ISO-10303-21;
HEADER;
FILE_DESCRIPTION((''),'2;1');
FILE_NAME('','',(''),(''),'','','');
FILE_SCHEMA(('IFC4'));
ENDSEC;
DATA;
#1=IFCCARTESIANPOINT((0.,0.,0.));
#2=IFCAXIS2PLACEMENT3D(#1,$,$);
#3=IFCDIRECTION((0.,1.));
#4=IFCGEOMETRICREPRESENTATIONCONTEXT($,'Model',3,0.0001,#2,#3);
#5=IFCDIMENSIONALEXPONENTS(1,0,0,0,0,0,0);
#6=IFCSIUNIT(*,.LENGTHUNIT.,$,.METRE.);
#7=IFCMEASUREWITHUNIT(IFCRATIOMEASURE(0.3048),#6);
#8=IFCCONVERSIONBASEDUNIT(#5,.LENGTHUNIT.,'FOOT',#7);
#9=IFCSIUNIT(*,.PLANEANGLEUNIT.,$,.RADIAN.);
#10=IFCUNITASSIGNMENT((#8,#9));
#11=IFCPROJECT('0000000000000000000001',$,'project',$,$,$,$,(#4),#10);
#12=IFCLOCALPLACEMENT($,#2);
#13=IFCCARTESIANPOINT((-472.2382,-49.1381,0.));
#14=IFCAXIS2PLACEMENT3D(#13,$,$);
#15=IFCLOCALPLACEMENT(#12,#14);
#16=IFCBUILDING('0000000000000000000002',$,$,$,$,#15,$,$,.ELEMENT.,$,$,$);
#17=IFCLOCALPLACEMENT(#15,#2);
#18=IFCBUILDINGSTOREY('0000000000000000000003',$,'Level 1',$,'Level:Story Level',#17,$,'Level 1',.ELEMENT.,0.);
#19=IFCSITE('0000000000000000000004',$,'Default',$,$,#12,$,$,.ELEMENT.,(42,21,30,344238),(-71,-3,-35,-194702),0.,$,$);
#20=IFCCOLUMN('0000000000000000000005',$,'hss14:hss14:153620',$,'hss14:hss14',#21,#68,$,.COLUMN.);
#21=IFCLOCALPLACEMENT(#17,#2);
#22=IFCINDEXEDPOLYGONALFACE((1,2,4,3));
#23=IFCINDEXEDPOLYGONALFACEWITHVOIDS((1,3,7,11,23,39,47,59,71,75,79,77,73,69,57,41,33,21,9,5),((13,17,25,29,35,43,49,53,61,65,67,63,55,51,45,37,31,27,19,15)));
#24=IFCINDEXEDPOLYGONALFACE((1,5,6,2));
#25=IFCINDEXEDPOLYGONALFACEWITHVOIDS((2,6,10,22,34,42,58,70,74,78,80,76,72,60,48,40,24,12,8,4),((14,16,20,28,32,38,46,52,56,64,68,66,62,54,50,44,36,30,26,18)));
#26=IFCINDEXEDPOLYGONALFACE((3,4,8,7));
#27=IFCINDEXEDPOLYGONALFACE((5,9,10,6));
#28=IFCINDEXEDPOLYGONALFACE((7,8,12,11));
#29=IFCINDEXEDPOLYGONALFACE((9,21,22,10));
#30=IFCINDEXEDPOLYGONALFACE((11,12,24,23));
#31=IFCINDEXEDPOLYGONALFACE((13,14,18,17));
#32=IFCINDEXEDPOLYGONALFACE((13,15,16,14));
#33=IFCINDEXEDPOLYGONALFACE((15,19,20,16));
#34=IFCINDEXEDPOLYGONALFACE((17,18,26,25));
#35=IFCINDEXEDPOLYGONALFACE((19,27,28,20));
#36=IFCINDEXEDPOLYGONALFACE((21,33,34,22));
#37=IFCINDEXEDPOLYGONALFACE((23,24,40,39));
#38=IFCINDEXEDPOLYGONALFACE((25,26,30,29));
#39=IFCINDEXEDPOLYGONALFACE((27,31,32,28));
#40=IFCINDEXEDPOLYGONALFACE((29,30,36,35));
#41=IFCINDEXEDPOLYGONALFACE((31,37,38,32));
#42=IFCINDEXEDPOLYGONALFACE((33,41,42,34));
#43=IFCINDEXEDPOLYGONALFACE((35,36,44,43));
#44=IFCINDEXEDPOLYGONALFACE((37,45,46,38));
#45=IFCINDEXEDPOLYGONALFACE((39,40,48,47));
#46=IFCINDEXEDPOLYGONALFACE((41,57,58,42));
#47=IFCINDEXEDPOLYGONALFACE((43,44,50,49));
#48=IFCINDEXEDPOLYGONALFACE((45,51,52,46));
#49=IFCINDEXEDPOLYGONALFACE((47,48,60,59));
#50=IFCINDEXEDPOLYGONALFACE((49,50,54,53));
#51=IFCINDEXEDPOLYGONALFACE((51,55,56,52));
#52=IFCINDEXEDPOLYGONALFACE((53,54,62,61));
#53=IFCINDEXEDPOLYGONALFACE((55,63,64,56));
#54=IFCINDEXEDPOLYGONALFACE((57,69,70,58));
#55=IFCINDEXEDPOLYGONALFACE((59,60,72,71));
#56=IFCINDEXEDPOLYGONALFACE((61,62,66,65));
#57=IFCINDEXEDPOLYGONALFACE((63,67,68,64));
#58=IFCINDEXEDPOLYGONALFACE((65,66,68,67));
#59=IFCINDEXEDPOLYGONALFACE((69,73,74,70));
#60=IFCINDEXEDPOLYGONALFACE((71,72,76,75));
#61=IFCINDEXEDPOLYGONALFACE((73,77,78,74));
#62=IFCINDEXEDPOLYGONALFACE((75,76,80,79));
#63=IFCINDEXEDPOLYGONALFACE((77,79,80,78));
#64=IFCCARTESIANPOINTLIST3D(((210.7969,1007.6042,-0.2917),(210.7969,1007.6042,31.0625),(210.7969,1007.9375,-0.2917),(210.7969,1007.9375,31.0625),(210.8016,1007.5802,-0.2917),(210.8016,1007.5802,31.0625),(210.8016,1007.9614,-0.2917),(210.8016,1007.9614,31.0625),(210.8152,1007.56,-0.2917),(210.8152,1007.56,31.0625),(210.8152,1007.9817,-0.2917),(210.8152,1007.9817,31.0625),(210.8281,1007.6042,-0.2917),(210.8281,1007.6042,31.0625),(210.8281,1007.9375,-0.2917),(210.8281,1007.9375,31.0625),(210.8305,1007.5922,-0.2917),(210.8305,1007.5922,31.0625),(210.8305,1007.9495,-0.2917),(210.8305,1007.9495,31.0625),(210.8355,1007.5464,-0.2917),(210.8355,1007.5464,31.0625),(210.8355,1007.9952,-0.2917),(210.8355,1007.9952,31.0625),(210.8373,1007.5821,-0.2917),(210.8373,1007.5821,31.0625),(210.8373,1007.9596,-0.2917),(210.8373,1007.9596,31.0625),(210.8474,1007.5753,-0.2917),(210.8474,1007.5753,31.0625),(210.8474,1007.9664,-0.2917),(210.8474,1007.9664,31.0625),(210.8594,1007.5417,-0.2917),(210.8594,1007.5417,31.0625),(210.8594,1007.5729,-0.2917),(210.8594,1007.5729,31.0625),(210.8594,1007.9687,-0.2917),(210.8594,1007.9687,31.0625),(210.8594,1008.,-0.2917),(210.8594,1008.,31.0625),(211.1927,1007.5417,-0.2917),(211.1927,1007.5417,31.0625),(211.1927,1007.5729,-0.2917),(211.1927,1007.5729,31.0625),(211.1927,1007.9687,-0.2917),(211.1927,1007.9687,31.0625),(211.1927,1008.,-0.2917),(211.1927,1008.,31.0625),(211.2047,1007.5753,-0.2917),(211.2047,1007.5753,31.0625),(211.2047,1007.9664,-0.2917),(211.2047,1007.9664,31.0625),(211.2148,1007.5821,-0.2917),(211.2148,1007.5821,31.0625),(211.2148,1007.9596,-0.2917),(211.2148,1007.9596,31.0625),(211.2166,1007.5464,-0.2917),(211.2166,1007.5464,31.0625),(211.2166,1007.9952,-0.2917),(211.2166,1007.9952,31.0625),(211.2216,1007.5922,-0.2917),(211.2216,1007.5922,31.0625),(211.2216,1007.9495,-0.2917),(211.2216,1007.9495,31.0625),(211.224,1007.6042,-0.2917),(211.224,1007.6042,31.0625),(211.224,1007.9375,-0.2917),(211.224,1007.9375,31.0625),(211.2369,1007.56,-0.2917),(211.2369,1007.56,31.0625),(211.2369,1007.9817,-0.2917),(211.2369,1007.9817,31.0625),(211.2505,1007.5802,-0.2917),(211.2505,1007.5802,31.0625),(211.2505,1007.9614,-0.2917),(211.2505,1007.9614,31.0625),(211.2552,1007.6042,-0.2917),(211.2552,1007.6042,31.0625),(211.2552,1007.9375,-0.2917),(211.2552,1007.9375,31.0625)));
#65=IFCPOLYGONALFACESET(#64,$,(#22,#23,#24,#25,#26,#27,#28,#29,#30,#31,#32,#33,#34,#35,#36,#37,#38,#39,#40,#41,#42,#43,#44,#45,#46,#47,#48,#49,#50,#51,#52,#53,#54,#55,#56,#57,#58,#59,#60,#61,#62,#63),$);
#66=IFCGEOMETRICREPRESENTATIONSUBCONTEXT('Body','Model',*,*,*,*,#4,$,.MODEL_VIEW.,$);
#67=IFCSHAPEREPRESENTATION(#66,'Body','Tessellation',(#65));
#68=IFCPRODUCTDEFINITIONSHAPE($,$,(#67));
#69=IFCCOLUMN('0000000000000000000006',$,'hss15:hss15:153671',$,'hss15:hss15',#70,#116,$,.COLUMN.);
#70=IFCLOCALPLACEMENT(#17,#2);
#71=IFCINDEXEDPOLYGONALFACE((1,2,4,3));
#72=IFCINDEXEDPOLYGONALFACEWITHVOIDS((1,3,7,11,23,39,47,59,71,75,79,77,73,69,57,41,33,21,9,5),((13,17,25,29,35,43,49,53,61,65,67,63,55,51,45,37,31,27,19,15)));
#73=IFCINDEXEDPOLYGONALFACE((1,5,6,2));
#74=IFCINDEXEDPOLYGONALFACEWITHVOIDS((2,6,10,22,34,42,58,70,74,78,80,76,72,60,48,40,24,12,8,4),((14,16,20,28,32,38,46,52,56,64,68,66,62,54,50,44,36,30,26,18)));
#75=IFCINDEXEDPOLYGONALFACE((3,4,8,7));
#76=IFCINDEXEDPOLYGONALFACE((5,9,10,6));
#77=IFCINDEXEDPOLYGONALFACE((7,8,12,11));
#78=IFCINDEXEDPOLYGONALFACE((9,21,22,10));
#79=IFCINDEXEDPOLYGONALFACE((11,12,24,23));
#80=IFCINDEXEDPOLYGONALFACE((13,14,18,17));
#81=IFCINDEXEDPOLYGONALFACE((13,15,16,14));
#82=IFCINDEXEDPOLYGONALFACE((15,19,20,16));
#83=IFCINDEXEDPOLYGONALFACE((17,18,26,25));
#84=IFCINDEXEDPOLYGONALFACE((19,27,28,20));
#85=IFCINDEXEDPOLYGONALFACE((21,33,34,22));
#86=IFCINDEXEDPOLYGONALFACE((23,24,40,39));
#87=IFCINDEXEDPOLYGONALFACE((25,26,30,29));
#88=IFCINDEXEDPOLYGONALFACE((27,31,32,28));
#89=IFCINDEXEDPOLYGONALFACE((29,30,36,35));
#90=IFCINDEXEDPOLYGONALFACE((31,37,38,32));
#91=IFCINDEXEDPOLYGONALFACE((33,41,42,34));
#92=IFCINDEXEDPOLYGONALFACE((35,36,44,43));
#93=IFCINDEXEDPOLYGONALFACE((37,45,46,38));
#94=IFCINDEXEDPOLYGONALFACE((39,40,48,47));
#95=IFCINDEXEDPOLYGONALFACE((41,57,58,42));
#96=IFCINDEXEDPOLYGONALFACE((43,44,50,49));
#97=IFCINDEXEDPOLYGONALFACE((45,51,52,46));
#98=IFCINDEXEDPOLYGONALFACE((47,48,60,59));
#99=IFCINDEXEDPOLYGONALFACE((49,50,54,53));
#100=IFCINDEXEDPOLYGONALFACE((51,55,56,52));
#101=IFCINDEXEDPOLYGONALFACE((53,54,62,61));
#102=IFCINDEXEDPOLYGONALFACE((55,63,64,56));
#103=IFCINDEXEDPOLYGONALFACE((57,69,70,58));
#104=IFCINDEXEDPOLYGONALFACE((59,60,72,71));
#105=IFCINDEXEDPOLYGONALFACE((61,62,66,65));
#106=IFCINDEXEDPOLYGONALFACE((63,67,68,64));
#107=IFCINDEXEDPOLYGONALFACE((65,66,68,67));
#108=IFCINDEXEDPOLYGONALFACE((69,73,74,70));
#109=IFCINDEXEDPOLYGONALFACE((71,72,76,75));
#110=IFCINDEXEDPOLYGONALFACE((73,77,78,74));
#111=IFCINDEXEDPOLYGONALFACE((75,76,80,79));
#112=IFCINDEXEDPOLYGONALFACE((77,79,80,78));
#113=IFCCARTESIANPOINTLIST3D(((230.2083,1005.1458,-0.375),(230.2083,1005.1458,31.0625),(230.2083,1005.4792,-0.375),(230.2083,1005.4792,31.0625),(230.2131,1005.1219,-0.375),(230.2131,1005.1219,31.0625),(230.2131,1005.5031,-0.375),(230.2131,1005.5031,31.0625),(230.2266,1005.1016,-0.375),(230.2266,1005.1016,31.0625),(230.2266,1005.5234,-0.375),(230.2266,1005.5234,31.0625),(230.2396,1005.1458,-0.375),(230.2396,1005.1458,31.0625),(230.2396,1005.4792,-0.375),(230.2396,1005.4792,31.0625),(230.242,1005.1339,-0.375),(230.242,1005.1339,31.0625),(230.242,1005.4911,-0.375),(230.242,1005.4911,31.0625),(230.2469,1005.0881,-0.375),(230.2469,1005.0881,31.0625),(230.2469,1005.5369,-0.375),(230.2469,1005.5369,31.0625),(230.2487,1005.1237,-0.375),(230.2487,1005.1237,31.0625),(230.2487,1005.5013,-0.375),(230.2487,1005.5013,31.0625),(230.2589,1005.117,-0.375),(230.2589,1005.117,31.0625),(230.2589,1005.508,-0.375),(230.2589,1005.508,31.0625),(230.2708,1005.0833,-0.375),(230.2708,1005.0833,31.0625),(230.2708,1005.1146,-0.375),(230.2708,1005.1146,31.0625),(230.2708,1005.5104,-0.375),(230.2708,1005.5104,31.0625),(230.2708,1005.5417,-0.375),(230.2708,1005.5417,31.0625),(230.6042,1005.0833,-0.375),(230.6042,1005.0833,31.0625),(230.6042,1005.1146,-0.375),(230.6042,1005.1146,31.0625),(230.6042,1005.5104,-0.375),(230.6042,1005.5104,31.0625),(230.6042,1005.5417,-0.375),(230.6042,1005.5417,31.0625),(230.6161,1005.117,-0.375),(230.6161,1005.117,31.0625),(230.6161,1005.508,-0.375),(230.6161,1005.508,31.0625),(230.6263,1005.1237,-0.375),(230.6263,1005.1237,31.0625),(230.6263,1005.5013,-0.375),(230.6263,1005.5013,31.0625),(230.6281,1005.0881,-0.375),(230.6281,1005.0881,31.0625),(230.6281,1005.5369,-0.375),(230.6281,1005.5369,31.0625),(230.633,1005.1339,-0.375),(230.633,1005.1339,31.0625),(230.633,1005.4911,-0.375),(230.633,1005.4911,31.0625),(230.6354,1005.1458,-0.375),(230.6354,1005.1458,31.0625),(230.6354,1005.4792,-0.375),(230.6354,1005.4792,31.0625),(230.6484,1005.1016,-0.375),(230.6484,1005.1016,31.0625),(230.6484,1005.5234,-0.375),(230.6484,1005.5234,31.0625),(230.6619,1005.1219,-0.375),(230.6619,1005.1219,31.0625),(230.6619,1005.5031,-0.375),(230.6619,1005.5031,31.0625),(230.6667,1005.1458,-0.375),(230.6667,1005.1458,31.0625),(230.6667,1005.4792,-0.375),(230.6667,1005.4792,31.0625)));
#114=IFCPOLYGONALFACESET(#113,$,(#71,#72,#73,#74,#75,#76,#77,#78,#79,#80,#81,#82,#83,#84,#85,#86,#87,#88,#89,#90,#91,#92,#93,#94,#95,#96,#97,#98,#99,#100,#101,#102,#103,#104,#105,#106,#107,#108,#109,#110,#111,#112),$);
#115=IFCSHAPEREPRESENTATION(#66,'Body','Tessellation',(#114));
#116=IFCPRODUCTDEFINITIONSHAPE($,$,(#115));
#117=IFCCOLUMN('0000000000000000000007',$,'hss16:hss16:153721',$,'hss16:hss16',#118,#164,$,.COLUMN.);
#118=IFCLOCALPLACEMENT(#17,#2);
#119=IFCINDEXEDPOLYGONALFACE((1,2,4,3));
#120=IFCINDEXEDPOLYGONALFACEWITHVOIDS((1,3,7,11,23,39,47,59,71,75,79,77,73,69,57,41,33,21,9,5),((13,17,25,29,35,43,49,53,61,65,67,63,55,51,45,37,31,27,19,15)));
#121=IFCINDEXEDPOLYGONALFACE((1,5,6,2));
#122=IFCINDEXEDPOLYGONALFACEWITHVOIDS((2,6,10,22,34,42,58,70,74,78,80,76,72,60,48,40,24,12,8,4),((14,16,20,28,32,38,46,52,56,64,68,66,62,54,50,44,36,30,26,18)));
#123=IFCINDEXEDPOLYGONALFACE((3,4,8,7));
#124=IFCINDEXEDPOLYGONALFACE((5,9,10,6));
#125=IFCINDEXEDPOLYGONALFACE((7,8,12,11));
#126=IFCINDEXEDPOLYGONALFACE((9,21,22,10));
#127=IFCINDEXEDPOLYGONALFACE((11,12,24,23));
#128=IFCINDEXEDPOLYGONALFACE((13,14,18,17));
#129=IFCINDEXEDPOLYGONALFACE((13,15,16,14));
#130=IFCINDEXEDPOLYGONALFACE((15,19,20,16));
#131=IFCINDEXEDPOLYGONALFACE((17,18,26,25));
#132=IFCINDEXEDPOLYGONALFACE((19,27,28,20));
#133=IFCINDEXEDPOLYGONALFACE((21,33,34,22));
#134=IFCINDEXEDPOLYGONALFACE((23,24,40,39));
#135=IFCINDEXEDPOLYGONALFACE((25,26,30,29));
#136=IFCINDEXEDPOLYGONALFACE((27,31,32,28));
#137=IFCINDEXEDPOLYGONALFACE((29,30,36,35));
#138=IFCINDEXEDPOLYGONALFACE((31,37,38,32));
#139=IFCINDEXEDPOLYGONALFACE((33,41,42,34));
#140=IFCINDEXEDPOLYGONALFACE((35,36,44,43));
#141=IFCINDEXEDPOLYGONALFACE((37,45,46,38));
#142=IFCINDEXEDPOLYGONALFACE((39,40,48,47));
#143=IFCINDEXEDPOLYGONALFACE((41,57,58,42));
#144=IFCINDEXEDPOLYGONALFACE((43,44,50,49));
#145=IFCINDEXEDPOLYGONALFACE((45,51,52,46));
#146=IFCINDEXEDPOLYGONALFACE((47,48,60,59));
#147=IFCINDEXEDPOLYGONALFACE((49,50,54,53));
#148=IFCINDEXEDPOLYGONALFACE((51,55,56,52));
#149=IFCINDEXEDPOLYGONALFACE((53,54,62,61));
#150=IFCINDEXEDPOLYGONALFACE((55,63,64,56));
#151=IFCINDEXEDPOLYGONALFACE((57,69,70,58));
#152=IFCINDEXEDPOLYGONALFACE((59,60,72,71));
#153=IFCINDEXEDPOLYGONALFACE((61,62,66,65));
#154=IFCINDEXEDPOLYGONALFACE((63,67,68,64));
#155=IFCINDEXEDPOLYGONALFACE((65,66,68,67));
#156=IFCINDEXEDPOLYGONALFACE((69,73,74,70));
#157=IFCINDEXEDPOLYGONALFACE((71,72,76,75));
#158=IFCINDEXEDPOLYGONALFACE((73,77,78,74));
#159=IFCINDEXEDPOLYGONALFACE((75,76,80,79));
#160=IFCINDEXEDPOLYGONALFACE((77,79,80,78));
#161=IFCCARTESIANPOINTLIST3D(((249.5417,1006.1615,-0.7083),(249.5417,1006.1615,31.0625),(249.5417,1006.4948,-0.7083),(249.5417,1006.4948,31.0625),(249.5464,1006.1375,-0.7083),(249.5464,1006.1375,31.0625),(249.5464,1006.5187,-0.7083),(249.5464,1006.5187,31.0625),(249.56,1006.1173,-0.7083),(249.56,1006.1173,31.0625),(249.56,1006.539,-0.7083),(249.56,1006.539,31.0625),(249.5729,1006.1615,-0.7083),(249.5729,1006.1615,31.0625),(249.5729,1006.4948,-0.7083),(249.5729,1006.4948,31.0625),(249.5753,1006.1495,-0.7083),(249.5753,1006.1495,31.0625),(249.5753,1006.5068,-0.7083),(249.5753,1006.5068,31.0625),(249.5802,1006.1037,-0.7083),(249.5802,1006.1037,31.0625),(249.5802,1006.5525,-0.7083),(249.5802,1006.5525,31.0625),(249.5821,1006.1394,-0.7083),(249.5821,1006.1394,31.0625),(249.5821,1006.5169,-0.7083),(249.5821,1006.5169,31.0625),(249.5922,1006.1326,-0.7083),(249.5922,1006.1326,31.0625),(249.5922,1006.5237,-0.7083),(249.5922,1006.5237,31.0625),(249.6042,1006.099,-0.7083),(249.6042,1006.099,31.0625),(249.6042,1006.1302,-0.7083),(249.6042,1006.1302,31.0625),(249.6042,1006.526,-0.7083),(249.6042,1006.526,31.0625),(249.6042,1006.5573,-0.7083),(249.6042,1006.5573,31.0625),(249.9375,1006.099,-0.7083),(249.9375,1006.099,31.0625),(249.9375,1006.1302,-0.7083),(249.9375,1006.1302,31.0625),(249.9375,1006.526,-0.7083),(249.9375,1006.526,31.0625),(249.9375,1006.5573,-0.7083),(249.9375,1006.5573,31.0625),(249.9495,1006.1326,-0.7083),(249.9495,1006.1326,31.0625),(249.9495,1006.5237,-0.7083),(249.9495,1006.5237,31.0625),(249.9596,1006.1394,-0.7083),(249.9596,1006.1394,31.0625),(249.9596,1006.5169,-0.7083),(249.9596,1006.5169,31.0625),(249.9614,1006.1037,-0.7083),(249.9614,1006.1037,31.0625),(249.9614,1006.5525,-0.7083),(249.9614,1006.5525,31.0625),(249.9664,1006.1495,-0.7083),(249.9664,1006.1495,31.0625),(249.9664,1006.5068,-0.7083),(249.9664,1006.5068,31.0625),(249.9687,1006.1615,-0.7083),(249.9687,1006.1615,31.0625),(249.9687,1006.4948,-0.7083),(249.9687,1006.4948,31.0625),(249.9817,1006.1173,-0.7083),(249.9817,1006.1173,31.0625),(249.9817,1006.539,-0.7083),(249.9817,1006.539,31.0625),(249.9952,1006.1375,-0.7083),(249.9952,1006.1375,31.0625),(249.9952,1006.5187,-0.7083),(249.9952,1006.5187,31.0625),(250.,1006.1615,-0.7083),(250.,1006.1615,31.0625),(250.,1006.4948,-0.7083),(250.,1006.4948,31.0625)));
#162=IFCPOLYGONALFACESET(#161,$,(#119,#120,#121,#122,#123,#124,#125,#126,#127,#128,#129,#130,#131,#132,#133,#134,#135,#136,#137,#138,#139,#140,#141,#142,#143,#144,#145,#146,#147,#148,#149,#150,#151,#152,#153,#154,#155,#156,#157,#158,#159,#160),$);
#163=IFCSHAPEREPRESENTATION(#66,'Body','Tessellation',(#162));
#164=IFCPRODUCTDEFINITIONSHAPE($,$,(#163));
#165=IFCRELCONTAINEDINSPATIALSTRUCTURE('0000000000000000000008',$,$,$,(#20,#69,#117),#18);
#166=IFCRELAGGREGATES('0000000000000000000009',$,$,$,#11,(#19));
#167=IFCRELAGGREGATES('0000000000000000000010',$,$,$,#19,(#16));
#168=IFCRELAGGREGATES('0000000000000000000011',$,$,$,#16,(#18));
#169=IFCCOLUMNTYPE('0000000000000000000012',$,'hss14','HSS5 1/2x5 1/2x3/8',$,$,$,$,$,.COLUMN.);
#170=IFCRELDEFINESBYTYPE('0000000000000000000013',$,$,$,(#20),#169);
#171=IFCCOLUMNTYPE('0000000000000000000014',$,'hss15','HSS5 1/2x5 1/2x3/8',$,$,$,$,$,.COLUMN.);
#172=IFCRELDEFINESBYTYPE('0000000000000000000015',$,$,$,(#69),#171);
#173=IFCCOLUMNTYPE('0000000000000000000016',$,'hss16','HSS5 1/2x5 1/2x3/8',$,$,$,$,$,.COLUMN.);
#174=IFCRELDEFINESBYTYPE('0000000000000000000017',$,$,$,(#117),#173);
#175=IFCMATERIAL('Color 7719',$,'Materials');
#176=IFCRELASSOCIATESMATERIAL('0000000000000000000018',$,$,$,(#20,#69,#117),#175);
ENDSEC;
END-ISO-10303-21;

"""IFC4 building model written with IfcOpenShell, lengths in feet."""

from ifc_helpers import new_model, entity, si_unit, converted_unit, direction, frame, origin, place, context, subcontext, project, spatial, polyline, outline, extrude, boolean, source, transform, mapped, material, type_object, type_shapes, element, save


model = new_model("IFC4")

# Units and contexts
model_context = context("Model", 3, precision=0.0001, world=origin(), true_north=direction((0.0, 1.0)))
body_context = subcontext(model_context, "Body", "Model", "MODEL_VIEW")
ifc_project = project(units=[converted_unit("LENGTHUNIT", "FOOT", entity("IfcRatioMeasure", 0.3048), si_unit("LENGTHUNIT", "METRE"), dimensions=[1, 0, 0, 0, 0, 0, 0]), si_unit("PLANEANGLEUNIT", "RADIAN")], contexts=[model_context])

# Site, building, storey
site_placement = place(None, origin())
site = spatial("IfcSite", under=ifc_project, at=site_placement, Name="Default", CompositionType="ELEMENT", RefLatitude=(42, 21, 30, 344238), RefLongitude=(-71, -3, -35, -194702), RefElevation=0.0)
building_placement = place(site_placement, frame((-472.2382, -49.1381, 0.0)))
building = spatial("IfcBuilding", under=site, at=building_placement, CompositionType="ELEMENT")
storey_placement = place(building_placement, origin())
storey = spatial("IfcBuildingStorey", under=building, at=storey_placement, Name="Level 1", ObjectType="Level:Story Level", LongName="Level 1", CompositionType="ELEMENT", Elevation=0.0)

# Columns
ifc_material_1 = material(Name="Color 7719", Category="Materials")
column_type_1 = type_object("IfcColumnType", Name="hss14", Description="HSS5 1/2x5 1/2x3/8", PredefinedType="COLUMN")
shared_shape_1 = source(origin(), body_context, "Body", "CSG", [
    boolean("DIFFERENCE", extrude(outline(polyline([(-0.1667, -0.2292), (0.1667, -0.2292), (0.1906, -0.2244), (0.2109, -0.2109), (0.2244, -0.1906), (0.2292, -0.1667), (0.2292, 0.1667), (0.2244, 0.1906), (0.2109, 0.2109), (0.1906, 0.2244), (0.1667, 0.2292), (-0.1667, 0.2292), (-0.1906, 0.2244), (-0.2109, 0.2109), (-0.2244, 0.1906), (-0.2292, 0.1667), (-0.2292, -0.1667), (-0.2244, -0.1906), (-0.2109, -0.2109), (-0.1906, -0.2244), (-0.1667, -0.2292)])), frame((211.026, 1007.7708, -0.2917), z_axis=(0.0, 0.0, 1.0), x_axis=(0.0, -1.0, 0.0)), (0.0, 0.0, 1.0), 31.3542), extrude(outline(polyline([(-0.1667, -0.1979), (0.1667, -0.1979), (0.1786, -0.1955), (0.1888, -0.1888), (0.1955, -0.1786), (0.1979, -0.1667), (0.1979, 0.1667), (0.1955, 0.1786), (0.1888, 0.1888), (0.1786, 0.1955), (0.1667, 0.1979), (-0.1667, 0.1979), (-0.1786, 0.1955), (-0.1888, 0.1888), (-0.1955, 0.1786), (-0.1979, 0.1667), (-0.1979, -0.1667), (-0.1955, -0.1786), (-0.1888, -0.1888), (-0.1786, -0.1955), (-0.1667, -0.1979)])), frame((211.026, 1007.7708, 31.0625), z_axis=(0.0, 0.0, -1.0), x_axis=(0.0, -1.0, 0.0)), (0.0, 0.0, 1.0), 31.3542)),
])
type_shapes(column_type_1, [shared_shape_1])
column_1_placement = place(building_placement, origin())
element("IfcColumn", 1, at=column_1_placement, inside=storey, type_object=column_type_1, material=ifc_material_1, Name="hss14:hss14:153620", ObjectType="hss14:hss14", PredefinedType="COLUMN", context=body_context, shape_type="MappedRepresentation", body=[
    mapped(shared_shape_1, transform((0.0, 0.0, 0.0), scale=1.0)),
])
column_type_2 = type_object("IfcColumnType", Name="hss15", Description="HSS5 1/2x5 1/2x3/8", PredefinedType="COLUMN")
shared_shape_2 = source(origin(), body_context, "Body", "CSG", [
    boolean("DIFFERENCE", extrude(outline(polyline([(-0.1667, -0.2292), (0.1667, -0.2292), (0.1906, -0.2244), (0.2109, -0.2109), (0.2244, -0.1906), (0.2292, -0.1667), (0.2292, 0.1667), (0.2244, 0.1906), (0.2109, 0.2109), (0.1906, 0.2244), (0.1667, 0.2292), (-0.1667, 0.2292), (-0.1906, 0.2244), (-0.2109, 0.2109), (-0.2244, 0.1906), (-0.2292, 0.1667), (-0.2292, -0.1667), (-0.2244, -0.1906), (-0.2109, -0.2109), (-0.1906, -0.2244), (-0.1667, -0.2292)])), frame((230.4375, 1005.3125, -0.375), z_axis=(0.0, 0.0, 1.0), x_axis=(0.0, -1.0, 0.0)), (0.0, 0.0, 1.0), 31.4375), extrude(outline(polyline([(-0.1667, -0.1979), (0.1667, -0.1979), (0.1786, -0.1955), (0.1888, -0.1888), (0.1955, -0.1786), (0.1979, -0.1667), (0.1979, 0.1667), (0.1955, 0.1786), (0.1888, 0.1888), (0.1786, 0.1955), (0.1667, 0.1979), (-0.1667, 0.1979), (-0.1786, 0.1955), (-0.1888, 0.1888), (-0.1955, 0.1786), (-0.1979, 0.1667), (-0.1979, -0.1667), (-0.1955, -0.1786), (-0.1888, -0.1888), (-0.1786, -0.1955), (-0.1667, -0.1979)])), frame((230.4375, 1005.3125, 31.0625), z_axis=(0.0, 0.0, -1.0), x_axis=(0.0, -1.0, 0.0)), (0.0, 0.0, 1.0), 31.4375)),
])
type_shapes(column_type_2, [shared_shape_2])
column_2_placement = place(building_placement, origin())
element("IfcColumn", 2, at=column_2_placement, inside=storey, type_object=column_type_2, material=ifc_material_1, Name="hss15:hss15:153671", ObjectType="hss15:hss15", PredefinedType="COLUMN", context=body_context, shape_type="MappedRepresentation", body=[
    mapped(shared_shape_2, transform((0.0, 0.0, 0.0), scale=1.0)),
])
column_type_3 = type_object("IfcColumnType", Name="hss16", Description="HSS5 1/2x5 1/2x3/8", PredefinedType="COLUMN")
shared_shape_3 = source(origin(), body_context, "Body", "CSG", [
    boolean("DIFFERENCE", extrude(outline(polyline([(-0.1667, -0.2292), (0.1667, -0.2292), (0.1906, -0.2244), (0.2109, -0.2109), (0.2244, -0.1906), (0.2292, -0.1667), (0.2292, 0.1667), (0.2244, 0.1906), (0.2109, 0.2109), (0.1906, 0.2244), (0.1667, 0.2292), (-0.1667, 0.2292), (-0.1906, 0.2244), (-0.2109, 0.2109), (-0.2244, 0.1906), (-0.2292, 0.1667), (-0.2292, -0.1667), (-0.2244, -0.1906), (-0.2109, -0.2109), (-0.1906, -0.2244), (-0.1667, -0.2292)])), frame((249.7708, 1006.3281, -0.7083), z_axis=(0.0, 0.0, 1.0), x_axis=(0.0, -1.0, 0.0)), (0.0, 0.0, 1.0), 31.7708), extrude(outline(polyline([(-0.1667, -0.1979), (0.1667, -0.1979), (0.1786, -0.1955), (0.1888, -0.1888), (0.1955, -0.1786), (0.1979, -0.1667), (0.1979, 0.1667), (0.1955, 0.1786), (0.1888, 0.1888), (0.1786, 0.1955), (0.1667, 0.1979), (-0.1667, 0.1979), (-0.1786, 0.1955), (-0.1888, 0.1888), (-0.1955, 0.1786), (-0.1979, 0.1667), (-0.1979, -0.1667), (-0.1955, -0.1786), (-0.1888, -0.1888), (-0.1786, -0.1955), (-0.1667, -0.1979)])), frame((249.7708, 1006.3281, 31.0625), z_axis=(0.0, 0.0, -1.0), x_axis=(0.0, -1.0, 0.0)), (0.0, 0.0, 1.0), 31.7708)),
])
type_shapes(column_type_3, [shared_shape_3])
column_3_placement = place(building_placement, origin())
element("IfcColumn", 3, at=column_3_placement, inside=storey, type_object=column_type_3, material=ifc_material_1, Name="hss16:hss16:153721", ObjectType="hss16:hss16", PredefinedType="COLUMN", context=body_context, shape_type="MappedRepresentation", body=[
    mapped(shared_shape_3, transform((0.0, 0.0, 0.0), scale=1.0)),
])

save(model, "model.ifc")
